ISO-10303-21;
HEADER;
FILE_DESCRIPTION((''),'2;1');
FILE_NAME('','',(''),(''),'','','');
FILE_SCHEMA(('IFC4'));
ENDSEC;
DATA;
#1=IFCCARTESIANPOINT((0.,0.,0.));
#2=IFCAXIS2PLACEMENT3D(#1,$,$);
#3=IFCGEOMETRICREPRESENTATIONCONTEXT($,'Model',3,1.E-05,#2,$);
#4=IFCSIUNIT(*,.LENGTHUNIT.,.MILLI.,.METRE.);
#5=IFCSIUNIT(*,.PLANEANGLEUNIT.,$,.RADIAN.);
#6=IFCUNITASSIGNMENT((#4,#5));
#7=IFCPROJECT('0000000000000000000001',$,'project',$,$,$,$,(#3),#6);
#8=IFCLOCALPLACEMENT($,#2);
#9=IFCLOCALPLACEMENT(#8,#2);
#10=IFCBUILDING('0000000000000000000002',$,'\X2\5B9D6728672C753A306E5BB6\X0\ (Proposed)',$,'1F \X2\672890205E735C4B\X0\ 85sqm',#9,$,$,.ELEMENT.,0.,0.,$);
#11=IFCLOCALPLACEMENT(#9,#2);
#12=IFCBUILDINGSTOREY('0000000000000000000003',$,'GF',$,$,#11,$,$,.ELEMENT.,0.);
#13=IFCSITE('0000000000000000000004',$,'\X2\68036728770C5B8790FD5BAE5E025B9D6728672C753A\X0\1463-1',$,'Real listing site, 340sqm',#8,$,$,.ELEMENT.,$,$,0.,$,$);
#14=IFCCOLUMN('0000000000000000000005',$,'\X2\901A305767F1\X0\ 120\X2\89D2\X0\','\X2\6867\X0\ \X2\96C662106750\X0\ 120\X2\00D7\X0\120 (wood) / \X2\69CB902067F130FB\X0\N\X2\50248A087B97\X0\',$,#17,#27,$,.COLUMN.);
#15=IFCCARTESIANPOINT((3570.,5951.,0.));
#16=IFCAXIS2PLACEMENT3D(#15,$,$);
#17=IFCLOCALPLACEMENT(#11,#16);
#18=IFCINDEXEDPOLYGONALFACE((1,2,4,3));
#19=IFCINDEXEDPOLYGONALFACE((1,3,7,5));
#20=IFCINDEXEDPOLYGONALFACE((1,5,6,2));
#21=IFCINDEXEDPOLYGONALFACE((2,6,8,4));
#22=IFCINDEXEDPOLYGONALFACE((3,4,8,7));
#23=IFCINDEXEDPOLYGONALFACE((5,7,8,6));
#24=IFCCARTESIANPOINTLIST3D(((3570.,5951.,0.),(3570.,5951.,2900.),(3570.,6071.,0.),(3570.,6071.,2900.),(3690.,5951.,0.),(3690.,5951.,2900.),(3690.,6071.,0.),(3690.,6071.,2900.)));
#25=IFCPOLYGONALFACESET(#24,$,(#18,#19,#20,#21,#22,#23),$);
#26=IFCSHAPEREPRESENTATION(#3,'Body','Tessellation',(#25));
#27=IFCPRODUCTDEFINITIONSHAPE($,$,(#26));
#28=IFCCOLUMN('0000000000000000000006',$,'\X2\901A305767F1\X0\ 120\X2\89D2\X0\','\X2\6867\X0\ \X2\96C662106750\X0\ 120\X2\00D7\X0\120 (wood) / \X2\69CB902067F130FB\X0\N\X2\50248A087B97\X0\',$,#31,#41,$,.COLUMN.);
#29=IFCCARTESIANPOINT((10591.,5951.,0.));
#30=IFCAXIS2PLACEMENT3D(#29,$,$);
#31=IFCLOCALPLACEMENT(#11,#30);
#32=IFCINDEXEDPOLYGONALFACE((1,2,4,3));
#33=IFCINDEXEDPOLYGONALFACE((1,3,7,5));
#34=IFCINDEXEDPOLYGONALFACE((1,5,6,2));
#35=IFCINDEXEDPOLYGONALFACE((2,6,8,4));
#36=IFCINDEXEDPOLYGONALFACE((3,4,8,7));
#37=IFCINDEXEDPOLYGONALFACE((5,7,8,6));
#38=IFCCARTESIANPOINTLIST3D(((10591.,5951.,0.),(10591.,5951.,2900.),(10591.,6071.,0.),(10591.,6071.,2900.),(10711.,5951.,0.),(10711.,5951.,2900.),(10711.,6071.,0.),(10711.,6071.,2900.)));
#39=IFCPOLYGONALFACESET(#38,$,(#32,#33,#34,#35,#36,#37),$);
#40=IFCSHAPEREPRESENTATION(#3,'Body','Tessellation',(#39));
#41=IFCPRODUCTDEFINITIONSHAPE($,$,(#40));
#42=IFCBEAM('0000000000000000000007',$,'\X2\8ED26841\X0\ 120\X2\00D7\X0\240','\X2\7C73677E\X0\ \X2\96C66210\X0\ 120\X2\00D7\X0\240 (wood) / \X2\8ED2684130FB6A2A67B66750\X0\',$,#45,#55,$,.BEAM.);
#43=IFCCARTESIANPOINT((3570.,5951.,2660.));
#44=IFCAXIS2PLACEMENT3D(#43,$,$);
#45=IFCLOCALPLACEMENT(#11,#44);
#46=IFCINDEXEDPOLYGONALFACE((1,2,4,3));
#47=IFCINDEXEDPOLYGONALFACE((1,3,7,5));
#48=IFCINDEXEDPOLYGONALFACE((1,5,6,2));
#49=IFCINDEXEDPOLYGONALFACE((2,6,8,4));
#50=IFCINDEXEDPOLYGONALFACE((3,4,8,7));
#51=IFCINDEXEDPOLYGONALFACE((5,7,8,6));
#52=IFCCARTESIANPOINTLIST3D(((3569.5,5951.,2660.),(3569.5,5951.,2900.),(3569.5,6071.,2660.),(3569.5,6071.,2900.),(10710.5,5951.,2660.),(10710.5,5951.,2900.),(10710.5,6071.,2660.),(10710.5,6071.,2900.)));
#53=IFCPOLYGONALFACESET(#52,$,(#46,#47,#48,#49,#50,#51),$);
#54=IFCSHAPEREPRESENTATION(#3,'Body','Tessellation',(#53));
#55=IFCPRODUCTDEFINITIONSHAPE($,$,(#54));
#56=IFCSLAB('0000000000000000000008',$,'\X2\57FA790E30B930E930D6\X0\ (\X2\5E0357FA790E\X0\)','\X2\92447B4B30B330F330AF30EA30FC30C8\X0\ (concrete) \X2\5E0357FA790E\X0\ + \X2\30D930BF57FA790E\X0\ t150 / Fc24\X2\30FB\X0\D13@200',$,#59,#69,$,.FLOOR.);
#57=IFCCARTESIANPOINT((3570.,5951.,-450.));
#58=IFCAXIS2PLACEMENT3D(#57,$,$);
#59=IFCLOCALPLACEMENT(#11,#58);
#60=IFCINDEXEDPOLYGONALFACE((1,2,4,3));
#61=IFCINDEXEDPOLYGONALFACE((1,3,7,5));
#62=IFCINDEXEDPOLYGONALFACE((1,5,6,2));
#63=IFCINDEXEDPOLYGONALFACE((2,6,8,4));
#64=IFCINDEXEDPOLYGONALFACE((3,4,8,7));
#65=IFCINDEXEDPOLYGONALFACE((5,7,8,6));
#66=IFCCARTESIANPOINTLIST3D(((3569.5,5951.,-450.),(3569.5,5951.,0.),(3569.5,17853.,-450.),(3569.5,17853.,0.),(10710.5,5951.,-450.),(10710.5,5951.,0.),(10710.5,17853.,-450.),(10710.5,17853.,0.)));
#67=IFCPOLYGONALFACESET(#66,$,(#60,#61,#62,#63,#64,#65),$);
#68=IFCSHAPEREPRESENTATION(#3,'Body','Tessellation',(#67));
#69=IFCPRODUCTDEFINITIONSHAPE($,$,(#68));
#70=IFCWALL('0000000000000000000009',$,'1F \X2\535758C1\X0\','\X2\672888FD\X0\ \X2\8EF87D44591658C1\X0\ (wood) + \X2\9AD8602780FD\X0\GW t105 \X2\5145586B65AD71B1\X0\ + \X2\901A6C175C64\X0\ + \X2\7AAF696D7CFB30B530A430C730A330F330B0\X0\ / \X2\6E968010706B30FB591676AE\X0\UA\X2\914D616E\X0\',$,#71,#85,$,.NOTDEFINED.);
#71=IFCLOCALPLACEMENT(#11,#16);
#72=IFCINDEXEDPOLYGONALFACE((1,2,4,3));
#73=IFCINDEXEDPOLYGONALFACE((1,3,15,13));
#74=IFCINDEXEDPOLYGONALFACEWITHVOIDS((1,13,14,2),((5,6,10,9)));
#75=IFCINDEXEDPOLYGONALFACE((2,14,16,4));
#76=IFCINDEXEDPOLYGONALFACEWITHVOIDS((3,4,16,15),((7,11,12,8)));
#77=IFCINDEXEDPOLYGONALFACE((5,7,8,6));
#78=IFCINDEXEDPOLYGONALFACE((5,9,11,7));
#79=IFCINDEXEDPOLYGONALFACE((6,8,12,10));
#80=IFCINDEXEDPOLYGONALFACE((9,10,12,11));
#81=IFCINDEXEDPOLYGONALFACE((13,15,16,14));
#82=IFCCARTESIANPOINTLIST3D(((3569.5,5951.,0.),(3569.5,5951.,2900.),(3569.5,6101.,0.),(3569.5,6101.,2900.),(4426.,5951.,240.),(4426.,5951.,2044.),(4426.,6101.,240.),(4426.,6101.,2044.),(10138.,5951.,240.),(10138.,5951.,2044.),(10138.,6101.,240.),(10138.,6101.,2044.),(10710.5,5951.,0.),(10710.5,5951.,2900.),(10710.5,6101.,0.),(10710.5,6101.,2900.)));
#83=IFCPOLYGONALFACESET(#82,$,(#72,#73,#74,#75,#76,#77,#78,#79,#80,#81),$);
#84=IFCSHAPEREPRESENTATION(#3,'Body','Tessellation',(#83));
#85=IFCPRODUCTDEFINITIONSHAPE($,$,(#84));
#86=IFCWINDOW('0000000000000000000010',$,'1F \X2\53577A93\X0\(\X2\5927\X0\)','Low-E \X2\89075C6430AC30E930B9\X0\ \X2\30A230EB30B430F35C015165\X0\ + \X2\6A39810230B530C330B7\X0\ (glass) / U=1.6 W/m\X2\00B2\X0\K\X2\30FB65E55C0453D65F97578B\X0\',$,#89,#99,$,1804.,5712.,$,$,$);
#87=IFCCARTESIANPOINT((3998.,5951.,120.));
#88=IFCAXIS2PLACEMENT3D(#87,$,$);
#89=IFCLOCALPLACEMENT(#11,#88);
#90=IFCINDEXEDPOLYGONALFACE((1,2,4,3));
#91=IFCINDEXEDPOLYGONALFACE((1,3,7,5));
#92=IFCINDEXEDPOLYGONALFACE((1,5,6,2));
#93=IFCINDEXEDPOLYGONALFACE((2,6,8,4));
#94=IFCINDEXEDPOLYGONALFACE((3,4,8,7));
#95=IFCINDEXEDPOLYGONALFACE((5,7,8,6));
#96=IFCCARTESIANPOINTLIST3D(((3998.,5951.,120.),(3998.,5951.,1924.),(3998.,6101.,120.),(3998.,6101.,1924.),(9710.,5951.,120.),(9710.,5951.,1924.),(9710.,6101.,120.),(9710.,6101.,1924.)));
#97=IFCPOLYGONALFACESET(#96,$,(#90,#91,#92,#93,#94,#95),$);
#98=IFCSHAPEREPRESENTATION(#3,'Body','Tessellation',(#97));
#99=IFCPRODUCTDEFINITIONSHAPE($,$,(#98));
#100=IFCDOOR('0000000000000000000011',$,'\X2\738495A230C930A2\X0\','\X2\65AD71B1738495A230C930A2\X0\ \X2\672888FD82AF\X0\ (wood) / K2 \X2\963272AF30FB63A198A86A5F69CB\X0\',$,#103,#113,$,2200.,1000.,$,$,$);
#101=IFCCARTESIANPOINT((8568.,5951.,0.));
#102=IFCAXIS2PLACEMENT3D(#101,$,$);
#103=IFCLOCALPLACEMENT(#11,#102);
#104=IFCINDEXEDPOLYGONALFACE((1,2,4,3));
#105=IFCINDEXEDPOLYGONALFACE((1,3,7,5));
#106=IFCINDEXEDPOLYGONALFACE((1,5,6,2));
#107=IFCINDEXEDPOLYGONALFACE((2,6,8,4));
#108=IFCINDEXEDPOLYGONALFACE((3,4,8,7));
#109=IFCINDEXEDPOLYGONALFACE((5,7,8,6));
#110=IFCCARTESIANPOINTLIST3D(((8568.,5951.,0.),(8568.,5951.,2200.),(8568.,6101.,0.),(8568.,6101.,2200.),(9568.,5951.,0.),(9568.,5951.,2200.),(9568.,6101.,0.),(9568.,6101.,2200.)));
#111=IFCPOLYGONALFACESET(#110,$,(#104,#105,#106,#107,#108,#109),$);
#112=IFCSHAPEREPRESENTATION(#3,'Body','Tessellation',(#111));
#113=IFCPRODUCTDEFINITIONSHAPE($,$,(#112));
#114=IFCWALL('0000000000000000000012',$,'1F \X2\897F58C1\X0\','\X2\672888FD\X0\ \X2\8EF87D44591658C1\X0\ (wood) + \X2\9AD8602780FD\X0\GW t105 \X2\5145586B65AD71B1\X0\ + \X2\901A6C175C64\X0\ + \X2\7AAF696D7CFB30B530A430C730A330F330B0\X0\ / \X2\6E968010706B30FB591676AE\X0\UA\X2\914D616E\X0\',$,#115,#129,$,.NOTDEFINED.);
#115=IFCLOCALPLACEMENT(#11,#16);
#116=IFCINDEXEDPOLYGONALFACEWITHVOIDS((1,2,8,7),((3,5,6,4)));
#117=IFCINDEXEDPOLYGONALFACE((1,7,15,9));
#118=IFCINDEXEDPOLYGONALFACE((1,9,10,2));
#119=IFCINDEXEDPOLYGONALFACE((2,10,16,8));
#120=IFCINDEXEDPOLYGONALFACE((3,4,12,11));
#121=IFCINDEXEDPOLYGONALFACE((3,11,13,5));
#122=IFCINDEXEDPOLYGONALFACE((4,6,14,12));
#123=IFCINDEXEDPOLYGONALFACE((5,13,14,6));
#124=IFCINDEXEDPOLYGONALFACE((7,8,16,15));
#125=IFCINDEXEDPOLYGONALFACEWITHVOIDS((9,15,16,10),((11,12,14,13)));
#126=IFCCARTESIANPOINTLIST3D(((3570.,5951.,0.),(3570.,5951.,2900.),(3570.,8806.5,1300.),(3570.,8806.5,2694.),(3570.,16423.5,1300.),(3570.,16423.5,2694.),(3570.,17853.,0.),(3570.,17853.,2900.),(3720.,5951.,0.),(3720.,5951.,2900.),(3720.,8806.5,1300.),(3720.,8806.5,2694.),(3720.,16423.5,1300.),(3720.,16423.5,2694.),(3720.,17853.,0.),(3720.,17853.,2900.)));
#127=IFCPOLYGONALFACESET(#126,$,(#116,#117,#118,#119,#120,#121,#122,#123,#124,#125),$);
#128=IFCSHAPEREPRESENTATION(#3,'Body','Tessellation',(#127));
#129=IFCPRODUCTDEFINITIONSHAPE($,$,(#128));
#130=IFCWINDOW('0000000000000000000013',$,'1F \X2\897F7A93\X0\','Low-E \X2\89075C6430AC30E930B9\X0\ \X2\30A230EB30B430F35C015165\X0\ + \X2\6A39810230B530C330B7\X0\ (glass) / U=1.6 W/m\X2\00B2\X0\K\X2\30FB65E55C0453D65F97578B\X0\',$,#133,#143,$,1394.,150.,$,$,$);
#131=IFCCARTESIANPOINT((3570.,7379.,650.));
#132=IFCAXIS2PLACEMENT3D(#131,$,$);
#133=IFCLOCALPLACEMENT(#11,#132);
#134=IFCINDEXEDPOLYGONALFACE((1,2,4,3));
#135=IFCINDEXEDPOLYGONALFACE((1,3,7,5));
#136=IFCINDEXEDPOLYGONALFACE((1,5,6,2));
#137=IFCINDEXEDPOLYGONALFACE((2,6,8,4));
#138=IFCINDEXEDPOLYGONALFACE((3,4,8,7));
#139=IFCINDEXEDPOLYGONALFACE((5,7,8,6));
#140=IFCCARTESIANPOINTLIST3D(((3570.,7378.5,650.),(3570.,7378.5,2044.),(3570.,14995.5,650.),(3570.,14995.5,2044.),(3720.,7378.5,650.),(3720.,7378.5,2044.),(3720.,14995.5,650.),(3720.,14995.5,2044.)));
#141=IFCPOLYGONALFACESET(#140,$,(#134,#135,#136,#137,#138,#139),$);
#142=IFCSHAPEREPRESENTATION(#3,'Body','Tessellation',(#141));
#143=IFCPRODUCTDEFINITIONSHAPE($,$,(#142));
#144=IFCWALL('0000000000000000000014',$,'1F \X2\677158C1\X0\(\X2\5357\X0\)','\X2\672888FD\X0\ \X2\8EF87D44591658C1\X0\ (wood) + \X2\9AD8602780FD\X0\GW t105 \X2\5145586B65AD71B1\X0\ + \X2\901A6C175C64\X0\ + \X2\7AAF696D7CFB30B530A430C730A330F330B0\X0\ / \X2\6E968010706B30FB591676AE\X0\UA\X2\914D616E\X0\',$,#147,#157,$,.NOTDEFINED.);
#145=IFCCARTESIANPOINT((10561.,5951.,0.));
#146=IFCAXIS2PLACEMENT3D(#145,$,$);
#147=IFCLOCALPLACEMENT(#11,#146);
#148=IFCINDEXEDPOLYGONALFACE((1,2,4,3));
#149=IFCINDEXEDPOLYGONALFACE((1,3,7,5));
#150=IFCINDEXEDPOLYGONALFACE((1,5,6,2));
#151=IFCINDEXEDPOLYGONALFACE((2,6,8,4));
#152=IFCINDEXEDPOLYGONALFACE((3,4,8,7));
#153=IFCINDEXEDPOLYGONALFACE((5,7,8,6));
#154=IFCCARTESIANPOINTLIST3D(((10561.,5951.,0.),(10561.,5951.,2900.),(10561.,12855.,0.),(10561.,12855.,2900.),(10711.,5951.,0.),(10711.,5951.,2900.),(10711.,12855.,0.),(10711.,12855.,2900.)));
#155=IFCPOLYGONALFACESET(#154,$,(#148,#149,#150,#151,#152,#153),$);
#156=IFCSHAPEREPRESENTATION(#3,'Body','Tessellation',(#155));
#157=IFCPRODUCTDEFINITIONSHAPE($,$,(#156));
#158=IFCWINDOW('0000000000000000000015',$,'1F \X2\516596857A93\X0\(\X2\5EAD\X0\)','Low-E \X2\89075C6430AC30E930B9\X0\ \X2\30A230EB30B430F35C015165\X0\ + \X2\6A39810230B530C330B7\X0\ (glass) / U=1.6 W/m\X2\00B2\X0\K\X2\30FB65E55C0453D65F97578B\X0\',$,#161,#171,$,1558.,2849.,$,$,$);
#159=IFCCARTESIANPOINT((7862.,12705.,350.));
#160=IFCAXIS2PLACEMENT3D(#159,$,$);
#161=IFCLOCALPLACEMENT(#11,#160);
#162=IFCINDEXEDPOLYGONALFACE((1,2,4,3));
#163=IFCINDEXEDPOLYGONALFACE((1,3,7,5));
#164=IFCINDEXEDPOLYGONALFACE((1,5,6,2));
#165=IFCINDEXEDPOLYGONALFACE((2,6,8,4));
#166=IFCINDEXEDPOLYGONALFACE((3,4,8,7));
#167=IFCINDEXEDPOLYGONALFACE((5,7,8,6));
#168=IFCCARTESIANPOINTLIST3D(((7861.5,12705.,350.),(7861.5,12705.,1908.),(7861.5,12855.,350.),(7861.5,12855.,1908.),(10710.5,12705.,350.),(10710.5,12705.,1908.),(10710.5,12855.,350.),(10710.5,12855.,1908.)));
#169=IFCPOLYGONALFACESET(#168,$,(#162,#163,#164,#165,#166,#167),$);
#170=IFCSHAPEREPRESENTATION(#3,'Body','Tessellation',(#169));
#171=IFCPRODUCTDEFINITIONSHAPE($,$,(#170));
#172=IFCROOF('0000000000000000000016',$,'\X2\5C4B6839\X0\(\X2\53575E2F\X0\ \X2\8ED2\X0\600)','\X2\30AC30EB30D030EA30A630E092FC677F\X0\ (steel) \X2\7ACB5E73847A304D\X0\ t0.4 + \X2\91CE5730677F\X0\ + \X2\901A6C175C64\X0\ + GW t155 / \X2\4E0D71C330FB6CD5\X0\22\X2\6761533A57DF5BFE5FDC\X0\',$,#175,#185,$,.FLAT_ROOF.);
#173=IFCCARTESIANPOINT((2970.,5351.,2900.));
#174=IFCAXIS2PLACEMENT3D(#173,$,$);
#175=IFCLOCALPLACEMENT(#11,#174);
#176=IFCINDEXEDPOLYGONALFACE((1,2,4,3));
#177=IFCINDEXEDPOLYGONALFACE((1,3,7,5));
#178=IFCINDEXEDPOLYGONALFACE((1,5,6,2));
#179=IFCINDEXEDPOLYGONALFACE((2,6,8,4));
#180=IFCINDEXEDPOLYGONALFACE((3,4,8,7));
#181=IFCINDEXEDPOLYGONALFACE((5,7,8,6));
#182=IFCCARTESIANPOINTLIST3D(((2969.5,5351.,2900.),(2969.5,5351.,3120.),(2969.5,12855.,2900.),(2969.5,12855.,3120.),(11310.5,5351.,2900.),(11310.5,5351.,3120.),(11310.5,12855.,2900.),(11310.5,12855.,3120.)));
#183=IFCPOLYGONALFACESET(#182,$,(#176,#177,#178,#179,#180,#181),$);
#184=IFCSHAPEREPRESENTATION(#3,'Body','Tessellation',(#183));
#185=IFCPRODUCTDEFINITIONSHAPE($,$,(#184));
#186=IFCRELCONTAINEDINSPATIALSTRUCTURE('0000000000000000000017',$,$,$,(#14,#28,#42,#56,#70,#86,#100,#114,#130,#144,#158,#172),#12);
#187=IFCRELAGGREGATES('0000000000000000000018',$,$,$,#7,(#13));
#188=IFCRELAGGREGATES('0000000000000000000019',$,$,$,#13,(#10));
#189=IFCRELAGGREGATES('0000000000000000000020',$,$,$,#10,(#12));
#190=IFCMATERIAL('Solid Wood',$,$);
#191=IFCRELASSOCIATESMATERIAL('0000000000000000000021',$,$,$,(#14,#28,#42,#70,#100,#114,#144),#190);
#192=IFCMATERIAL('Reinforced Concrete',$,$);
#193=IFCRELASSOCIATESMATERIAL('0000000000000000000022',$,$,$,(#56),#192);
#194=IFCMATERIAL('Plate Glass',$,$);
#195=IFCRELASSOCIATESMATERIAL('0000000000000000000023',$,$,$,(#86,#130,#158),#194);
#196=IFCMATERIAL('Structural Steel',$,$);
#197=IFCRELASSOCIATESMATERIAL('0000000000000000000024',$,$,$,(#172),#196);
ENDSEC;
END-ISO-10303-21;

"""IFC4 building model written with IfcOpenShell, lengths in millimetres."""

from ifc_helpers import new_model, si_unit, frame, frame_2d, origin, place, context, project, spatial, rectangle, extrude, material, element, fill, save


model = new_model("IFC4")

# Units and contexts
model_context = context("Model", 3, precision=1e-05, world=origin())
ifc_project = project(units=[si_unit("LENGTHUNIT", "METRE", prefix="MILLI"), si_unit("PLANEANGLEUNIT", "RADIAN")], contexts=[model_context])

# Site, building, storey
site_placement = place(None, origin())
site = spatial("IfcSite", under=ifc_project, at=site_placement, Name="栃木県宇都宮市宝木本町1463-1", ObjectType="Real listing site, 340sqm", CompositionType="ELEMENT", RefElevation=0.0)
building_placement = place(site_placement, origin())
building = spatial("IfcBuilding", under=site, at=building_placement, Name="宝木本町の家 (Proposed)", ObjectType="1F 木造平屋 85sqm", CompositionType="ELEMENT", ElevationOfRefHeight=0.0, ElevationOfTerrain=0.0)
storey_placement = place(building_placement, origin())
storey = spatial("IfcBuildingStorey", under=building, at=storey_placement, Name="GF", CompositionType="ELEMENT", Elevation=0.0)

# Columns
ifc_material_1 = material(Name="Solid Wood")
column_1_placement = place(storey_placement, frame((3570.0, 5951.0, 0.0)))
element("IfcColumn", 1, at=column_1_placement, inside=storey, material=ifc_material_1, Name="通し柱 120角", Description="桧 集成材 120×120 (wood) / 構造柱・N値計算", PredefinedType="COLUMN", context=model_context, shape_type="SweptSolid", body=[
    extrude(rectangle(XDim=120.0, YDim=120.0, at=frame_2d((60.0, 60.0))), frame((3570.0, 5951.0, 0.0)), (0.0, 0.0, 1.0), 2900.0),
])
column_2_placement = place(storey_placement, frame((10591.0, 5951.0, 0.0)))
element("IfcColumn", 2, at=column_2_placement, inside=storey, material=ifc_material_1, Name="通し柱 120角", Description="桧 集成材 120×120 (wood) / 構造柱・N値計算", PredefinedType="COLUMN", context=model_context, shape_type="SweptSolid", body=[
    extrude(rectangle(XDim=120.0, YDim=120.0, at=frame_2d((60.0, 60.0))), frame((10591.0, 5951.0, 0.0)), (0.0, 0.0, 1.0), 2900.0),
])

# Beam
beam_1_placement = place(storey_placement, frame((3570.0, 5951.0, 2660.0)))
element("IfcBeam", 3, at=beam_1_placement, inside=storey, material=ifc_material_1, Name="軒桁 120×240", Description="米松 集成 120×240 (wood) / 軒桁・横架材", PredefinedType="BEAM", context=model_context, shape_type="SweptSolid", body=[
    extrude(rectangle(XDim=7141.0, YDim=120.0, at=frame_2d((3570.0, 60.0))), frame((3570.0, 5951.0, 2660.0)), (0.0, 0.0, 1.0), 240.0),
])

# Slab
ifc_material_2 = material(Name="Reinforced Concrete")
slab_1_placement = place(storey_placement, frame((3570.0, 5951.0, -450.0)))
element("IfcSlab", 4, at=slab_1_placement, inside=storey, material=ifc_material_2, Name="基礎スラブ (布基礎)", Description="鉄筋コンクリート (concrete) 布基礎 + ベタ基礎 t150 / Fc24・D13@200", PredefinedType="FLOOR", context=model_context, shape_type="SweptSolid", body=[
    extrude(rectangle(XDim=7141.0, YDim=11902.0, at=frame_2d((3570.0, 5951.0))), frame((3570.0, 5951.0, -450.0)), (0.0, 0.0, 1.0), 450.0),
])

# Wall, openings, window, door
wall_1_placement = place(storey_placement, frame((3570.0, 5951.0, 0.0)))
wall_1 = element("IfcWall", 5, at=wall_1_placement, inside=storey, material=ifc_material_1, Name="1F 南壁", Description="木製 軸組外壁 (wood) + 高性能GW t105 充填断熱 + 通気層 + 窯業系サイディング / 準耐火・外皮UA配慮", PredefinedType="NOTDEFINED", context=model_context, shape_type="SweptSolid", body=[
    extrude(rectangle(XDim=7141.0, YDim=150.0, at=frame_2d((3570.0, 75.0))), frame((3570.0, 5951.0, 0.0)), (0.0, 0.0, 1.0), 2900.0),
])
opening_1_placement = place(storey_placement, frame((3998.0, 5951.0, 120.0)))
opening_1 = element("IfcOpeningElement", 6, at=opening_1_placement, cuts=wall_1, PredefinedType="NOTDEFINED", context=model_context, shape_type="SweptSolid", body=[
    extrude(rectangle(XDim=5712.0, YDim=150.0, at=frame_2d((2856.0, 75.0))), frame((3998.0, 5951.0, 120.0)), (0.0, 0.0, 1.0), 1804.0),
])
opening_2_placement = place(storey_placement, frame((8568.0, 5951.0, 0.0)))
opening_2 = element("IfcOpeningElement", 7, at=opening_2_placement, cuts=wall_1, PredefinedType="NOTDEFINED", context=model_context, shape_type="SweptSolid", body=[
    extrude(rectangle(XDim=1000.0, YDim=150.0, at=frame_2d((500.0, 75.0))), frame((8568.0, 5951.0, 0.0)), (0.0, 0.0, 1.0), 2200.0),
])
ifc_material_3 = material(Name="Plate Glass")
window_1_placement = place(storey_placement, frame((3998.0, 5951.0, 120.0)))
window_1 = element("IfcWindow", 8, at=window_1_placement, inside=storey, material=ifc_material_3, Name="1F 南窓(大)", Description="Low-E 複層ガラス アルゴン封入 + 樹脂サッシ (glass) / U=1.6 W/m²K・日射取得型", OverallHeight=1804.0, OverallWidth=5712.0, context=model_context, shape_type="SweptSolid", body=[
    extrude(rectangle(XDim=5712.0, YDim=150.0, at=frame_2d((2856.0, 75.0))), frame((3998.0, 5951.0, 120.0)), (0.0, 0.0, 1.0), 1804.0),
])
fill(opening_1, window_1)
door_1_placement = place(storey_placement, frame((8568.0, 5951.0, 0.0)))
door_1 = element("IfcDoor", 9, at=door_1_placement, inside=storey, material=ifc_material_1, Name="玄関ドア", Description="断熱玄関ドア 木製芯 (wood) / K2 防犯・採風機構", OverallHeight=2200.0, OverallWidth=1000.0, context=model_context, shape_type="SweptSolid", body=[
    extrude(rectangle(XDim=1000.0, YDim=150.0, at=frame_2d((500.0, 75.0))), frame((8568.0, 5951.0, 0.0)), (0.0, 0.0, 1.0), 2200.0),
])
fill(opening_2, door_1)

# Walls, openings, windows
wall_2_placement = place(storey_placement, frame((3570.0, 5951.0, 0.0)))
wall_2 = element("IfcWall", 10, at=wall_2_placement, inside=storey, material=ifc_material_1, Name="1F 西壁", Description="木製 軸組外壁 (wood) + 高性能GW t105 充填断熱 + 通気層 + 窯業系サイディング / 準耐火・外皮UA配慮", PredefinedType="NOTDEFINED", context=model_context, shape_type="SweptSolid", body=[
    extrude(rectangle(XDim=150.0, YDim=11902.0, at=frame_2d((75.0, 5951.0))), frame((3570.0, 5951.0, 0.0)), (0.0, 0.0, 1.0), 2900.0),
])
opening_3_placement = place(storey_placement, frame((3570.0, 7379.0, 650.0)))
opening_3 = element("IfcOpeningElement", 11, at=opening_3_placement, cuts=wall_2, PredefinedType="NOTDEFINED", context=model_context, shape_type="SweptSolid", body=[
    extrude(rectangle(XDim=150.0, YDim=7617.0, at=frame_2d((75.0, 3808.0))), frame((3570.0, 7379.0, 650.0)), (0.0, 0.0, 1.0), 1394.0),
])
window_2_placement = place(storey_placement, frame((3570.0, 7379.0, 650.0)))
window_2 = element("IfcWindow", 12, at=window_2_placement, inside=storey, material=ifc_material_3, Name="1F 西窓", Description="Low-E 複層ガラス アルゴン封入 + 樹脂サッシ (glass) / U=1.6 W/m²K・日射取得型", OverallHeight=1394.0, OverallWidth=150.0, context=model_context, shape_type="SweptSolid", body=[
    extrude(rectangle(XDim=150.0, YDim=7617.0, at=frame_2d((75.0, 3808.0))), frame((3570.0, 7379.0, 650.0)), (0.0, 0.0, 1.0), 1394.0),
])
fill(opening_3, window_2)
wall_3_placement = place(storey_placement, frame((10561.0, 5951.0, 0.0)))
wall_3 = element("IfcWall", 13, at=wall_3_placement, inside=storey, material=ifc_material_1, Name="1F 東壁(南)", Description="木製 軸組外壁 (wood) + 高性能GW t105 充填断熱 + 通気層 + 窯業系サイディング / 準耐火・外皮UA配慮", PredefinedType="NOTDEFINED", context=model_context, shape_type="SweptSolid", body=[
    extrude(rectangle(XDim=150.0, YDim=6904.0, at=frame_2d((75.0, 3452.0))), frame((10561.0, 5951.0, 0.0)), (0.0, 0.0, 1.0), 2900.0),
])
opening_4_placement = place(storey_placement, frame((7862.0, 12705.0, 350.0)))
opening_4 = element("IfcOpeningElement", 14, at=opening_4_placement, cuts=wall_3, PredefinedType="NOTDEFINED", context=model_context, shape_type="SweptSolid", body=[
    extrude(rectangle(XDim=2849.0, YDim=150.0, at=frame_2d((1424.0, 75.0))), frame((7862.0, 12705.0, 350.0)), (0.0, 0.0, 1.0), 1558.0),
])
window_3_placement = place(storey_placement, frame((7862.0, 12705.0, 350.0)))
window_3 = element("IfcWindow", 15, at=window_3_placement, inside=storey, material=ifc_material_3, Name="1F 入隅窓(庭)", Description="Low-E 複層ガラス アルゴン封入 + 樹脂サッシ (glass) / U=1.6 W/m²K・日射取得型", OverallHeight=1558.0, OverallWidth=2849.0, context=model_context, shape_type="SweptSolid", body=[
    extrude(rectangle(XDim=2849.0, YDim=150.0, at=frame_2d((1424.0, 75.0))), frame((7862.0, 12705.0, 350.0)), (0.0, 0.0, 1.0), 1558.0),
])
fill(opening_4, window_3)

# Roof
ifc_material_4 = material(Name="Structural Steel")
roof_placement = place(storey_placement, frame((2970.0, 5351.0, 2900.0)))
element("IfcRoof", 16, at=roof_placement, inside=storey, material=ifc_material_4, Name="屋根(南帯 軒600)", Description="ガルバリウム鋼板 (steel) 立平葺き t0.4 + 野地板 + 通気層 + GW t155 / 不燃・法22条区域対応", PredefinedType="FLAT_ROOF", context=model_context, shape_type="SweptSolid", body=[
    extrude(rectangle(XDim=8341.0, YDim=7504.0, at=frame_2d((4170.0, 3752.0))), frame((2970.0, 5351.0, 2900.0)), (0.0, 0.0, 1.0), 220.0),
])

save(model, "model.ifc")
